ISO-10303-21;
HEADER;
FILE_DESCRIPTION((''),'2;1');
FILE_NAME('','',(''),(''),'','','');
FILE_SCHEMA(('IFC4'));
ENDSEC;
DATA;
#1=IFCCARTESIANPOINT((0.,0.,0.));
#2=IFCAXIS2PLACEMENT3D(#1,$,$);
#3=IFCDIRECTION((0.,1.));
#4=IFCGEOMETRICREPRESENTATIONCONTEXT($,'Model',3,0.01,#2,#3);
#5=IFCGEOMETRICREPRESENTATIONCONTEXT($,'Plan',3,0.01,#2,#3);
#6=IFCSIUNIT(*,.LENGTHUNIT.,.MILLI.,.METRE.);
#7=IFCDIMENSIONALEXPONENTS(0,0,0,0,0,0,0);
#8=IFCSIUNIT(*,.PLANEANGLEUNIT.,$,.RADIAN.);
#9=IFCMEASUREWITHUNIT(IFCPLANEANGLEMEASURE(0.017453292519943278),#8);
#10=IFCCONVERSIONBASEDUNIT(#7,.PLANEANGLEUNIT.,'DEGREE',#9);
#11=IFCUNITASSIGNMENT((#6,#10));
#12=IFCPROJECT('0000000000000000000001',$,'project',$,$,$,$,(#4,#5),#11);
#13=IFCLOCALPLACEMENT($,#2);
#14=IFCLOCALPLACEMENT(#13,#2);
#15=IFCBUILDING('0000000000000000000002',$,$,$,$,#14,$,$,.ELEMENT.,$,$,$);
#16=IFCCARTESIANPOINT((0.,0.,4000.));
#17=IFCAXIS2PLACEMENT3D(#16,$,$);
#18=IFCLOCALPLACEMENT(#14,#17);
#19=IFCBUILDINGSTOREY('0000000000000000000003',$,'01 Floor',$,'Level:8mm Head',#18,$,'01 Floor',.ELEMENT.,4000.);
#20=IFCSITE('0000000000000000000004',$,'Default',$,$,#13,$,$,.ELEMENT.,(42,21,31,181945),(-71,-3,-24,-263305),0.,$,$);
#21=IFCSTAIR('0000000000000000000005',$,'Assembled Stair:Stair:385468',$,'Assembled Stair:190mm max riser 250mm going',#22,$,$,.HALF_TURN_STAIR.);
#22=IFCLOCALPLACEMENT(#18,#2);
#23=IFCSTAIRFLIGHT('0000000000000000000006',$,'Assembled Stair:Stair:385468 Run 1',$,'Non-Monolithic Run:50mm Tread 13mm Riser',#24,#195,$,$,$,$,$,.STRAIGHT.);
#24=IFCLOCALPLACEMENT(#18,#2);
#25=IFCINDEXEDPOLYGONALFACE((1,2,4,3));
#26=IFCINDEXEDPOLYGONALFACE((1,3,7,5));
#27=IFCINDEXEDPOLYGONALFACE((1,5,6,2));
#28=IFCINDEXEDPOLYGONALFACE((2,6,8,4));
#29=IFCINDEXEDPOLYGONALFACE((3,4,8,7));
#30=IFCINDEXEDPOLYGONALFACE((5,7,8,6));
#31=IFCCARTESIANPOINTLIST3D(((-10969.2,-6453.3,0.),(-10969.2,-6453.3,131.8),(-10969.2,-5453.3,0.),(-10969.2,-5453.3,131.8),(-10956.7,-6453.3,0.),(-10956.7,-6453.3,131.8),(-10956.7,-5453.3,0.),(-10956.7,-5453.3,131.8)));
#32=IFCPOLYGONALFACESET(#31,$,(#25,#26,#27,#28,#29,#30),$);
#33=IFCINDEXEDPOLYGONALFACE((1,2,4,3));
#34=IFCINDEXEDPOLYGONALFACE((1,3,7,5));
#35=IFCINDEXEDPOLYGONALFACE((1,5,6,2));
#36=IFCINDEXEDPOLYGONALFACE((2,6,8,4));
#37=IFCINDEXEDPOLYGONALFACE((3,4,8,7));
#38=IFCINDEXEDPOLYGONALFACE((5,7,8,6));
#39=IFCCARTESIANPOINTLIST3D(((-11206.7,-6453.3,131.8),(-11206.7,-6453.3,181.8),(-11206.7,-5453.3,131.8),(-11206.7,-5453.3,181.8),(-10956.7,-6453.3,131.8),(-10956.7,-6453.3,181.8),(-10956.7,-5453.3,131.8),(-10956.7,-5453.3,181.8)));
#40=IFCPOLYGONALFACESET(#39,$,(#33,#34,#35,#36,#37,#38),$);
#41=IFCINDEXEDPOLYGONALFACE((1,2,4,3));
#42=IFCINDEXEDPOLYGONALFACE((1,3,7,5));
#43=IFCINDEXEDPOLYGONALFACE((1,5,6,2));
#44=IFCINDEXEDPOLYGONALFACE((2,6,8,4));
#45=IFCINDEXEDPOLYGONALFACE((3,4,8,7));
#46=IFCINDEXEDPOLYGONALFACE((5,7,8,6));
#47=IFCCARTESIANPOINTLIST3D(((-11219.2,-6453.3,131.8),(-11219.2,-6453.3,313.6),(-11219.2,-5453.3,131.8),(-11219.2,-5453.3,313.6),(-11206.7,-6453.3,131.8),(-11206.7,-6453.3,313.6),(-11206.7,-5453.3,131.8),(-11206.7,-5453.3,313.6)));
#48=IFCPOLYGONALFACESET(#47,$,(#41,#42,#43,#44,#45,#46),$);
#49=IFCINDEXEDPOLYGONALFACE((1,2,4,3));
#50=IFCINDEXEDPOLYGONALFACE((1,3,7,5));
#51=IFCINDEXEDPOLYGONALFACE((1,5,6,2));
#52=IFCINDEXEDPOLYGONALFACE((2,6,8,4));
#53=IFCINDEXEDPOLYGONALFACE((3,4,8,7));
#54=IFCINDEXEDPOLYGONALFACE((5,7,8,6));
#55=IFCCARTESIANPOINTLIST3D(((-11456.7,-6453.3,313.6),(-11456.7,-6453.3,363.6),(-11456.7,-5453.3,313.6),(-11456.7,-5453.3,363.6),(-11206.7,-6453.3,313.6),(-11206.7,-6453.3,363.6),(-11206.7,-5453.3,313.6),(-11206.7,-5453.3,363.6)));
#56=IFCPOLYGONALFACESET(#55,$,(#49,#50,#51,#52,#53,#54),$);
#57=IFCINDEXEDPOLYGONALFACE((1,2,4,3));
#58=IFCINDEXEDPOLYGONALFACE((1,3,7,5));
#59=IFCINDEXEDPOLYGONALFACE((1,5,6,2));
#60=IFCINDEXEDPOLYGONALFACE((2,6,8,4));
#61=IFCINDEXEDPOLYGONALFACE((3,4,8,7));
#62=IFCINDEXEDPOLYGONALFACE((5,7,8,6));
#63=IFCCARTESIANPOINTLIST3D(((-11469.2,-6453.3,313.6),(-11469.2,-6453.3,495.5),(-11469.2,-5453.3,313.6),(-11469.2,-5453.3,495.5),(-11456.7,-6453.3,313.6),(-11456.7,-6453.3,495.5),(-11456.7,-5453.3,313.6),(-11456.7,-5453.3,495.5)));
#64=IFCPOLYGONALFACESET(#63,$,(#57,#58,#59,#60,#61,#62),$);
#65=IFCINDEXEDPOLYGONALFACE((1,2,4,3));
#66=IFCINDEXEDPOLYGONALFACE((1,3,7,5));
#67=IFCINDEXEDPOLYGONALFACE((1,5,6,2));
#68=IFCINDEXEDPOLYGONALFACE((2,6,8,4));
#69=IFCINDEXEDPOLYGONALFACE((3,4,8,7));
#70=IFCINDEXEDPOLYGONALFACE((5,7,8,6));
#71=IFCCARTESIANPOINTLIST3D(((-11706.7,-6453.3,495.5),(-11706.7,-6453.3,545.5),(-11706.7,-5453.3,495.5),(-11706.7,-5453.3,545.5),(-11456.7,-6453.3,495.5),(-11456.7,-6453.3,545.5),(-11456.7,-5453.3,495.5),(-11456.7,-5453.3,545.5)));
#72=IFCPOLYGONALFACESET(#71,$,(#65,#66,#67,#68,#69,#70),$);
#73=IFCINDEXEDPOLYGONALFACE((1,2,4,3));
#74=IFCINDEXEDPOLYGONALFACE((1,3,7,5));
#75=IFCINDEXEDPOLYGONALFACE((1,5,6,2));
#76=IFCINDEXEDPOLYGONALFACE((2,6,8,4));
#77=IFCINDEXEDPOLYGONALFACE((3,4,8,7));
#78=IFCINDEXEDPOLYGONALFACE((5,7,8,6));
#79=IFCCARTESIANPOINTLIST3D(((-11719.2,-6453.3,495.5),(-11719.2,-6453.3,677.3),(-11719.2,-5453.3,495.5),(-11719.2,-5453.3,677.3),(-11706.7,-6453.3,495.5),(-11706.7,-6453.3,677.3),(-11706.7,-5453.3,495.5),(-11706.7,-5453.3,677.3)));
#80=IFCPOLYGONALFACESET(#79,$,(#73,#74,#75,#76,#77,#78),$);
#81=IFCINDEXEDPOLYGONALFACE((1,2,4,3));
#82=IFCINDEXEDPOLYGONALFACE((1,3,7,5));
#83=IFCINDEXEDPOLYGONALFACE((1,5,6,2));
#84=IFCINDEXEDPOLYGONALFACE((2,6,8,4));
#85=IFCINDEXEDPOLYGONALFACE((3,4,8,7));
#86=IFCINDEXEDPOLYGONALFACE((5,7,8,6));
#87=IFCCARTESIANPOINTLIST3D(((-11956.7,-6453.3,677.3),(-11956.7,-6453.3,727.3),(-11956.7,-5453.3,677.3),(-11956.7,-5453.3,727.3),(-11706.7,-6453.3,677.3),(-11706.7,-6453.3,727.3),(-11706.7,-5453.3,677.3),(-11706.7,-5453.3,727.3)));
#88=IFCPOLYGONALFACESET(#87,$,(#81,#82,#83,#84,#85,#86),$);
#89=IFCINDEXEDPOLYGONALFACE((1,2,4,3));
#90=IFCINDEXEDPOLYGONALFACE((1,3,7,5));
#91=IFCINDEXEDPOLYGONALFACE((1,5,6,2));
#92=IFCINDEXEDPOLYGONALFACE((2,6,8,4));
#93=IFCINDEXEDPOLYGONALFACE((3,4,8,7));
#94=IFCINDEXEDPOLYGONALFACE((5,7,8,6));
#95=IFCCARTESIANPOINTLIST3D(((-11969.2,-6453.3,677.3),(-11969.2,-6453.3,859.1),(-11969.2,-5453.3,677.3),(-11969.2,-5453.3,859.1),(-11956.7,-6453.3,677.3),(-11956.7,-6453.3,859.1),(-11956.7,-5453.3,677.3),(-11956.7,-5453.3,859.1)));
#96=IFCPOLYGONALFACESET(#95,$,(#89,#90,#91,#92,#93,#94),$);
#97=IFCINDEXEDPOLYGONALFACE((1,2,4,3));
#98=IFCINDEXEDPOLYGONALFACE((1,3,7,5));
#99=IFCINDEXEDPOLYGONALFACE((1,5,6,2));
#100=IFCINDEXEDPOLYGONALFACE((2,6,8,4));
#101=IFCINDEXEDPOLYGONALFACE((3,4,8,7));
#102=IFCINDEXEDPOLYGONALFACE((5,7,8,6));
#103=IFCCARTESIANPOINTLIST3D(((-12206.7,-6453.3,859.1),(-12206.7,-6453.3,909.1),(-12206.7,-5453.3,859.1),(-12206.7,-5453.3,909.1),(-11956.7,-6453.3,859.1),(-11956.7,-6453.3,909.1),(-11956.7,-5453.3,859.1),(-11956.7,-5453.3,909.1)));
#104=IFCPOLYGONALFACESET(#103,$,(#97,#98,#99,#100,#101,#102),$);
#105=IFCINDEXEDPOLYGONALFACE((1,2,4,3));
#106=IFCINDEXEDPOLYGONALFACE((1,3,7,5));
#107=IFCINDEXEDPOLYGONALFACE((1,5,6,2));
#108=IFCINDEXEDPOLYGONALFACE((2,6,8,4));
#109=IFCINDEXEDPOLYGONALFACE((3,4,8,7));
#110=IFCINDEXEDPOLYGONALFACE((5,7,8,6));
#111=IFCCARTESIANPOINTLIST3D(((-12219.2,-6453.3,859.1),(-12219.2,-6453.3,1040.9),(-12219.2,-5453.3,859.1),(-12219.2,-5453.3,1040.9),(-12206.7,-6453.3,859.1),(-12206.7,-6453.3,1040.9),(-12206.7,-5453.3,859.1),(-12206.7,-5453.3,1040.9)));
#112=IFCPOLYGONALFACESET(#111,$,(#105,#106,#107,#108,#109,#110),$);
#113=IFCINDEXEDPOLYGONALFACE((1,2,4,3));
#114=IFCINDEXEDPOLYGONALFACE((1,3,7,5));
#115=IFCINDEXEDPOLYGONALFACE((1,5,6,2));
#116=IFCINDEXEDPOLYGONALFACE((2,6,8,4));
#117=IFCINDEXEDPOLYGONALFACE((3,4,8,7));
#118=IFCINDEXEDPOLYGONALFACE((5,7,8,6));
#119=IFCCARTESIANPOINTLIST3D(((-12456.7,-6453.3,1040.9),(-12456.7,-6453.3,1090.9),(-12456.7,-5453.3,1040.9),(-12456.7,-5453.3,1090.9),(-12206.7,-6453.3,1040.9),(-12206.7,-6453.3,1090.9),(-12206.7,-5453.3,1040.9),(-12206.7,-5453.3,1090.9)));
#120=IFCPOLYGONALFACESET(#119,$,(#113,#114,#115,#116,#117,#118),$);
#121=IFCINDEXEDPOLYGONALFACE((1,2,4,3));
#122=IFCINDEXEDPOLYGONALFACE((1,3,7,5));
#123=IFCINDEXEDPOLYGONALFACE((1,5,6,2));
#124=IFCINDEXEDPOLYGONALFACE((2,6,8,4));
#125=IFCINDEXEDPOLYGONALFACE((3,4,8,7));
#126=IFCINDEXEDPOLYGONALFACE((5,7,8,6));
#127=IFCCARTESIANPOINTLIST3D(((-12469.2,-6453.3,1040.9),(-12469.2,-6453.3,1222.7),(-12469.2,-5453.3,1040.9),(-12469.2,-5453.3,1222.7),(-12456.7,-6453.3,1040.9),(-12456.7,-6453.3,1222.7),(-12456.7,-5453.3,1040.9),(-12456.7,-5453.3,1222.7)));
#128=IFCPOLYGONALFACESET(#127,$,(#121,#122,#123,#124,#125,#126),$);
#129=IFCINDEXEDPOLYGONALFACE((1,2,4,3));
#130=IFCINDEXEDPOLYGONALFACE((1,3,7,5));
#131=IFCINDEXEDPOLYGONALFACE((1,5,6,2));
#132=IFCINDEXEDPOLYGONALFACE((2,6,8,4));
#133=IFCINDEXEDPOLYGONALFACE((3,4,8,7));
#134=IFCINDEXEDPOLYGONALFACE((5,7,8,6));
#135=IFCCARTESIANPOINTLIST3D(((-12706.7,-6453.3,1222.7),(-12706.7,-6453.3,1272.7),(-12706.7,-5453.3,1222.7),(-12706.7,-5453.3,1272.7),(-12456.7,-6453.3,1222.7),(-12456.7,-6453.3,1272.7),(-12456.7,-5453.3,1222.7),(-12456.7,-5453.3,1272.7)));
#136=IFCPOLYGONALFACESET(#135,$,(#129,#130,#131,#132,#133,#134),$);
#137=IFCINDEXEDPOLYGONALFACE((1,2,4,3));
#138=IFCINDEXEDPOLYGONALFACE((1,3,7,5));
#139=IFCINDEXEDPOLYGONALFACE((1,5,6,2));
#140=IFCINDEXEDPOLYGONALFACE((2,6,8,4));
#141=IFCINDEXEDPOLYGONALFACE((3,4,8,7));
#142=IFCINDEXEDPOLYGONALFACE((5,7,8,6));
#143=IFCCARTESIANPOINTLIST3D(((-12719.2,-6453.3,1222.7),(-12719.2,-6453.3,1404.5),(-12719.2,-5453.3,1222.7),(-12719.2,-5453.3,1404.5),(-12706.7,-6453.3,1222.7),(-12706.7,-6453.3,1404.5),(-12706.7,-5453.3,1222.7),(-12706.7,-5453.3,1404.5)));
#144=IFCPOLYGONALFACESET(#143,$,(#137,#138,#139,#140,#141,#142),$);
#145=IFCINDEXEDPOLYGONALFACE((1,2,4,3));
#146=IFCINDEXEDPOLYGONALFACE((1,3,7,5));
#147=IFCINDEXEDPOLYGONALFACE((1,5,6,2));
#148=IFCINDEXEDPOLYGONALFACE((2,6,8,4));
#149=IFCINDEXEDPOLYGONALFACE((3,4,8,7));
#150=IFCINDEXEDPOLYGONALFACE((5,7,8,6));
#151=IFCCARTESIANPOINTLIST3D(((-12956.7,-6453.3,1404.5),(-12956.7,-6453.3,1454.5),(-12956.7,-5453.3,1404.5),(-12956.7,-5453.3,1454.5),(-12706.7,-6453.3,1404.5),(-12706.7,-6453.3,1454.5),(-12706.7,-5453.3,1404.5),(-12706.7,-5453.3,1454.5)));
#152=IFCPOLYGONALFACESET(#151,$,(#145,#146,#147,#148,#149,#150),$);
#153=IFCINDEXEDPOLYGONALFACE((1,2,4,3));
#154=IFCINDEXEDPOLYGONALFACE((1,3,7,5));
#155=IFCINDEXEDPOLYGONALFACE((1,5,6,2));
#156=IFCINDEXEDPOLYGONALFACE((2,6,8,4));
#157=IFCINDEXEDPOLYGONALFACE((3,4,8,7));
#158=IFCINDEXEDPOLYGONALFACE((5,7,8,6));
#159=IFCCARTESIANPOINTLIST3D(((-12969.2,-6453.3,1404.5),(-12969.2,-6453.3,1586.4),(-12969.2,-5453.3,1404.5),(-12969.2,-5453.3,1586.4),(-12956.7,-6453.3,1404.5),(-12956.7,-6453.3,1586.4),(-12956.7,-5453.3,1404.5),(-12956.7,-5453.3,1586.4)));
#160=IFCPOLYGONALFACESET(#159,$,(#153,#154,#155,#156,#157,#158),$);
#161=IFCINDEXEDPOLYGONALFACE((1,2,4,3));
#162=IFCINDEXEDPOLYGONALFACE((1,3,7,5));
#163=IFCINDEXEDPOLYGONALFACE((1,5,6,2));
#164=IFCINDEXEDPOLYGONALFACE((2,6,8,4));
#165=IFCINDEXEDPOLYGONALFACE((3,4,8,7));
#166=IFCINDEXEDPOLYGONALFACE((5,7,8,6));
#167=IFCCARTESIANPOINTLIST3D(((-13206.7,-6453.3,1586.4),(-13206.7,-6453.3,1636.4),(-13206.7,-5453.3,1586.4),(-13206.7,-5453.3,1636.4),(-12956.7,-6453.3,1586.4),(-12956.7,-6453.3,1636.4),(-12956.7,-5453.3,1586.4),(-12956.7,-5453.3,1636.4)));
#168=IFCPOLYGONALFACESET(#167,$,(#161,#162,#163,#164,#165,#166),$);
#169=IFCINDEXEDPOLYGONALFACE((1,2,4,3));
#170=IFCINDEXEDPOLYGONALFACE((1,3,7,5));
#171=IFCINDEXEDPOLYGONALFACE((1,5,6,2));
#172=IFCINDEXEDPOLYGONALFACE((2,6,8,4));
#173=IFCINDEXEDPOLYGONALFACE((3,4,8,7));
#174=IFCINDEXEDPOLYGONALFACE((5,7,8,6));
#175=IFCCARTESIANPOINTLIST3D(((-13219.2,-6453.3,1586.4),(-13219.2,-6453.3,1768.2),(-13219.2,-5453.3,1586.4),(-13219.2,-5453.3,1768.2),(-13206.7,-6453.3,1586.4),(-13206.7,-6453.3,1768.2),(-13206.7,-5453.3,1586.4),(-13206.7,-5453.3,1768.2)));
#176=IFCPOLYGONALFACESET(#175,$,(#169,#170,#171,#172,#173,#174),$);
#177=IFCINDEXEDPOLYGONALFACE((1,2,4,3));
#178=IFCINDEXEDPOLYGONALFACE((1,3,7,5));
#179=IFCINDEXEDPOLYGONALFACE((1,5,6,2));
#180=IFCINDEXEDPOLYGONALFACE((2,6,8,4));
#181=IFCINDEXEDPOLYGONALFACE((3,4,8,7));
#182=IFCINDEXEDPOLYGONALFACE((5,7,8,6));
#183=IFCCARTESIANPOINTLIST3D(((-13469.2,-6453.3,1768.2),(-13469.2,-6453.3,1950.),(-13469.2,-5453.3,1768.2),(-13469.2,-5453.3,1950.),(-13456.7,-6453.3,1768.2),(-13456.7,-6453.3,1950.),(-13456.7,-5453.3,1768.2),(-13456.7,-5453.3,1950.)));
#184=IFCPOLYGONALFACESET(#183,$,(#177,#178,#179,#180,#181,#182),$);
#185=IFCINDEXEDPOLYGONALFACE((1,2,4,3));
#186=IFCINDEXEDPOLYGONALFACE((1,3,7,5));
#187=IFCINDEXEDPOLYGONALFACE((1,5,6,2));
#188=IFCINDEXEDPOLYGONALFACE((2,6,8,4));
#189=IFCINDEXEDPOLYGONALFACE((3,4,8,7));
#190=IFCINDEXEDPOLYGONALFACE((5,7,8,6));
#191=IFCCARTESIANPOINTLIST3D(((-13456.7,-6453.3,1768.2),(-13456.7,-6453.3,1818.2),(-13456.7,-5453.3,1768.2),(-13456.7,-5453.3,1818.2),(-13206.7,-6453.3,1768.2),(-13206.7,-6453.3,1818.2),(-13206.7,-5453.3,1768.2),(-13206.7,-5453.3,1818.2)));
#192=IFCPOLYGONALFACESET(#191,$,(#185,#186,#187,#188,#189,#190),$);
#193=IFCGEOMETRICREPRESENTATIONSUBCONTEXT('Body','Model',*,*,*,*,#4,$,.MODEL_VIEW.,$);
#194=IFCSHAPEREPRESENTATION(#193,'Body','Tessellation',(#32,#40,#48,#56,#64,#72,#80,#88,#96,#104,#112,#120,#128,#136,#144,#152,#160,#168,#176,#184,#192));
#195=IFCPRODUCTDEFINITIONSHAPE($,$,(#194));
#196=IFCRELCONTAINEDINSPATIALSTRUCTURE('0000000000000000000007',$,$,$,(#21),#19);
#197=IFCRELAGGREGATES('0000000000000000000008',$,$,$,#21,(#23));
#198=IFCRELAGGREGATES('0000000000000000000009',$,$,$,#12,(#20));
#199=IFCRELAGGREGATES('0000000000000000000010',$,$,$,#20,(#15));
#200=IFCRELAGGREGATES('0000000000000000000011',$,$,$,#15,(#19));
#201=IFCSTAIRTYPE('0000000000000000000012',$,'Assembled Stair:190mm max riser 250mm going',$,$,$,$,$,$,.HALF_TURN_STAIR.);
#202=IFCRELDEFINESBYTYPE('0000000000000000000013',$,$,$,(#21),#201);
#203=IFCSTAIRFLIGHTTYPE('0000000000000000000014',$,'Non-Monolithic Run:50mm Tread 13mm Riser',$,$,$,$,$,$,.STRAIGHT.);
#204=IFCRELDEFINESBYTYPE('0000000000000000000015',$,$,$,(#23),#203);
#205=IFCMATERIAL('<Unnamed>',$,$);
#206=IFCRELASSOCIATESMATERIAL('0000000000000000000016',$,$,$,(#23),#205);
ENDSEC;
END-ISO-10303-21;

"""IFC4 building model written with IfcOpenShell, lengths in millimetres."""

from ifc_helpers import new_model, entity, si_unit, converted_unit, direction, frame, origin, place, context, subcontext, project, spatial, indexed_curve, outline, extrude, material, type_object, element, aggregate, save


model = new_model("IFC4")

# Units and contexts
model_context = context("Model", 3, precision=0.01, world=origin(), true_north=direction((0.0, 1.0)))
plan_context = context("Plan", 3, precision=0.01, world=origin(), true_north=direction((0.0, 1.0)))
body_context = subcontext(model_context, "Body", "Model", "MODEL_VIEW")
ifc_project = project(units=[si_unit("LENGTHUNIT", "METRE", prefix="MILLI"), converted_unit("PLANEANGLEUNIT", "DEGREE", entity("IfcPlaneAngleMeasure", 0.017453292519943278), si_unit("PLANEANGLEUNIT", "RADIAN"), dimensions=[0, 0, 0, 0, 0, 0, 0])], contexts=[model_context, plan_context])

# Site, building, storey
site_placement = place(None, origin())
site = spatial("IfcSite", under=ifc_project, at=site_placement, Name="Default", CompositionType="ELEMENT", RefLatitude=(42, 21, 31, 181945), RefLongitude=(-71, -3, -24, -263305), RefElevation=0.0)
building_placement = place(site_placement, origin())
building = spatial("IfcBuilding", under=site, at=building_placement, CompositionType="ELEMENT")
storey_placement = place(building_placement, frame((0.0, 0.0, 4000.0)))
storey = spatial("IfcBuildingStorey", under=building, at=storey_placement, Name="01 Floor", ObjectType="Level:8mm Head", LongName="01 Floor", CompositionType="ELEMENT", Elevation=4000.0)

# Stair
stair_type = type_object("IfcStairType", Name="Assembled Stair:190mm max riser 250mm going", PredefinedType="HALF_TURN_STAIR")
stair_placement = place(storey_placement, origin())
stair = element("IfcStair", 1, at=stair_placement, inside=storey, type_object=stair_type, Name="Assembled Stair:Stair:385468", ObjectType="Assembled Stair:190mm max riser 250mm going", PredefinedType="HALF_TURN_STAIR")
ifc_material_1 = material(Name="<Unnamed>")

# Stair flight
stair_flight_type = type_object("IfcStairFlightType", Name="Non-Monolithic Run:50mm Tread 13mm Riser", PredefinedType="STRAIGHT")
stair_flight_1_placement = place(stair_placement, origin())
stair_flight_1 = element("IfcStairFlight", 2, at=stair_flight_1_placement, type_object=stair_flight_type, material=ifc_material_1, Name="Assembled Stair:Stair:385468 Run 1", ObjectType="Non-Monolithic Run:50mm Tread 13mm Riser", PredefinedType="STRAIGHT", context=body_context, shape_type="SweptSolid", body=[
    extrude(outline(indexed_curve([(-500.0, -6.3), (500.0, -6.3), (500.0, 6.2), (-500.0, 6.2), (-500.0, -6.3)], self_intersect=False)), frame((-10962.9, -5953.3, 0.0), z_axis=(0.0, 0.0, 1.0), x_axis=(0.0, -1.0, 0.0)), (0.0, 0.0, 1.0), 131.8),
    extrude(outline(indexed_curve([(-125.0, -500.0), (125.0, -500.0), (125.0, 500.0), (-125.0, 500.0), (-125.0, -500.0)], self_intersect=False)), frame((-11081.7, -5953.3, 131.8)), (0.0, 0.0, 1.0), 50.0),
    extrude(outline(indexed_curve([(-500.0, -6.2), (500.0, -6.2), (500.0, 6.3), (-500.0, 6.3), (-500.0, -6.2)], self_intersect=False)), frame((-11212.9, -5953.3, 131.8), z_axis=(0.0, 0.0, 1.0), x_axis=(0.0, -1.0, 0.0)), (0.0, 0.0, 1.0), 181.8),
    extrude(outline(indexed_curve([(-125.0, -500.0), (125.0, -500.0), (125.0, 500.0), (-125.0, 500.0), (-125.0, -500.0)], self_intersect=False)), frame((-11331.7, -5953.3, 313.6)), (0.0, 0.0, 1.0), 50.0),
    extrude(outline(indexed_curve([(-500.0, -6.3), (500.0, -6.3), (500.0, 6.2), (-500.0, 6.2), (-500.0, -6.3)], self_intersect=False)), frame((-11462.9, -5953.3, 313.6), z_axis=(0.0, 0.0, 1.0), x_axis=(0.0, -1.0, 0.0)), (0.0, 0.0, 1.0), 181.8),
    extrude(outline(indexed_curve([(-125.0, -500.0), (125.0, -500.0), (125.0, 500.0), (-125.0, 500.0), (-125.0, -500.0)], self_intersect=False)), frame((-11581.7, -5953.3, 495.5)), (0.0, 0.0, 1.0), 50.0),
    extrude(outline(indexed_curve([(-500.0, -6.2), (500.0, -6.2), (500.0, 6.3), (-500.0, 6.3), (-500.0, -6.2)], self_intersect=False)), frame((-11712.9, -5953.3, 495.5), z_axis=(0.0, 0.0, 1.0), x_axis=(0.0, -1.0, 0.0)), (0.0, 0.0, 1.0), 181.8),
    extrude(outline(indexed_curve([(-125.0, -500.0), (125.0, -500.0), (125.0, 500.0), (-125.0, 500.0), (-125.0, -500.0)], self_intersect=False)), frame((-11831.7, -5953.3, 677.3)), (0.0, 0.0, 1.0), 50.0),
    extrude(outline(indexed_curve([(-500.0, -6.2), (500.0, -6.2), (500.0, 6.3), (-500.0, 6.3), (-500.0, -6.2)], self_intersect=False)), frame((-11962.9, -5953.3, 677.3), z_axis=(0.0, 0.0, 1.0), x_axis=(0.0, -1.0, 0.0)), (0.0, 0.0, 1.0), 181.8),
    extrude(outline(indexed_curve([(-125.0, -500.0), (125.0, -500.0), (125.0, 500.0), (-125.0, 500.0), (-125.0, -500.0)], self_intersect=False)), frame((-12081.7, -5953.3, 859.1)), (0.0, 0.0, 1.0), 50.0),
    extrude(outline(indexed_curve([(-500.0, -6.2), (500.0, -6.2), (500.0, 6.3), (-500.0, 6.3), (-500.0, -6.2)], self_intersect=False)), frame((-12212.9, -5953.3, 859.1), z_axis=(0.0, 0.0, 1.0), x_axis=(0.0, -1.0, 0.0)), (0.0, 0.0, 1.0), 181.8),
    extrude(outline(indexed_curve([(-125.0, -500.0), (125.0, -500.0), (125.0, 500.0), (-125.0, 500.0), (-125.0, -500.0)], self_intersect=False)), frame((-12331.7, -5953.3, 1040.9)), (0.0, 0.0, 1.0), 50.0),
    extrude(outline(indexed_curve([(-500.0, -6.2), (500.0, -6.2), (500.0, 6.3), (-500.0, 6.3), (-500.0, -6.2)], self_intersect=False)), frame((-12462.9, -5953.3, 1040.9), z_axis=(0.0, 0.0, 1.0), x_axis=(0.0, -1.0, 0.0)), (0.0, 0.0, 1.0), 181.8),
    extrude(outline(indexed_curve([(-125.0, -500.0), (125.0, -500.0), (125.0, 500.0), (-125.0, 500.0), (-125.0, -500.0)], self_intersect=False)), frame((-12581.7, -5953.3, 1222.7)), (0.0, 0.0, 1.0), 50.0),
    extrude(outline(indexed_curve([(-500.0, -6.3), (500.0, -6.3), (500.0, 6.2), (-500.0, 6.2), (-500.0, -6.3)], self_intersect=False)), frame((-12712.9, -5953.3, 1222.7), z_axis=(0.0, 0.0, 1.0), x_axis=(0.0, -1.0, 0.0)), (0.0, 0.0, 1.0), 181.8),
    extrude(outline(indexed_curve([(-125.0, -500.0), (125.0, -500.0), (125.0, 500.0), (-125.0, 500.0), (-125.0, -500.0)], self_intersect=False)), frame((-12831.7, -5953.3, 1404.5)), (0.0, 0.0, 1.0), 50.0),
    extrude(outline(indexed_curve([(-500.0, -6.2), (500.0, -6.2), (500.0, 6.3), (-500.0, 6.3), (-500.0, -6.2)], self_intersect=False)), frame((-12962.9, -5953.3, 1404.5), z_axis=(0.0, 0.0, 1.0), x_axis=(0.0, -1.0, 0.0)), (0.0, 0.0, 1.0), 181.8),
    extrude(outline(indexed_curve([(-125.0, -500.0), (125.0, -500.0), (125.0, 500.0), (-125.0, 500.0), (-125.0, -500.0)], self_intersect=False)), frame((-13081.7, -5953.3, 1586.4)), (0.0, 0.0, 1.0), 50.0),
    extrude(outline(indexed_curve([(-500.0, -6.3), (500.0, -6.3), (500.0, 6.2), (-500.0, 6.2), (-500.0, -6.3)], self_intersect=False)), frame((-13212.9, -5953.3, 1586.4), z_axis=(0.0, 0.0, 1.0), x_axis=(0.0, -1.0, 0.0)), (0.0, 0.0, 1.0), 181.8),
    extrude(outline(indexed_curve([(-500.0, -6.3), (500.0, -6.3), (500.0, 6.2), (-500.0, 6.2), (-500.0, -6.3)], self_intersect=False)), frame((-13462.9, -5953.3, 1768.2), z_axis=(0.0, 0.0, 1.0), x_axis=(0.0, -1.0, 0.0)), (0.0, 0.0, 1.0), 181.8),
    extrude(outline(indexed_curve([(-125.0, -500.0), (125.0, -500.0), (125.0, 500.0), (-125.0, 500.0), (-125.0, -500.0)], self_intersect=False)), frame((-13331.7, -5953.3, 1768.2)), (0.0, 0.0, 1.0), 50.0),
])
aggregate(stair, [stair_flight_1])

save(model, "model.ifc")
